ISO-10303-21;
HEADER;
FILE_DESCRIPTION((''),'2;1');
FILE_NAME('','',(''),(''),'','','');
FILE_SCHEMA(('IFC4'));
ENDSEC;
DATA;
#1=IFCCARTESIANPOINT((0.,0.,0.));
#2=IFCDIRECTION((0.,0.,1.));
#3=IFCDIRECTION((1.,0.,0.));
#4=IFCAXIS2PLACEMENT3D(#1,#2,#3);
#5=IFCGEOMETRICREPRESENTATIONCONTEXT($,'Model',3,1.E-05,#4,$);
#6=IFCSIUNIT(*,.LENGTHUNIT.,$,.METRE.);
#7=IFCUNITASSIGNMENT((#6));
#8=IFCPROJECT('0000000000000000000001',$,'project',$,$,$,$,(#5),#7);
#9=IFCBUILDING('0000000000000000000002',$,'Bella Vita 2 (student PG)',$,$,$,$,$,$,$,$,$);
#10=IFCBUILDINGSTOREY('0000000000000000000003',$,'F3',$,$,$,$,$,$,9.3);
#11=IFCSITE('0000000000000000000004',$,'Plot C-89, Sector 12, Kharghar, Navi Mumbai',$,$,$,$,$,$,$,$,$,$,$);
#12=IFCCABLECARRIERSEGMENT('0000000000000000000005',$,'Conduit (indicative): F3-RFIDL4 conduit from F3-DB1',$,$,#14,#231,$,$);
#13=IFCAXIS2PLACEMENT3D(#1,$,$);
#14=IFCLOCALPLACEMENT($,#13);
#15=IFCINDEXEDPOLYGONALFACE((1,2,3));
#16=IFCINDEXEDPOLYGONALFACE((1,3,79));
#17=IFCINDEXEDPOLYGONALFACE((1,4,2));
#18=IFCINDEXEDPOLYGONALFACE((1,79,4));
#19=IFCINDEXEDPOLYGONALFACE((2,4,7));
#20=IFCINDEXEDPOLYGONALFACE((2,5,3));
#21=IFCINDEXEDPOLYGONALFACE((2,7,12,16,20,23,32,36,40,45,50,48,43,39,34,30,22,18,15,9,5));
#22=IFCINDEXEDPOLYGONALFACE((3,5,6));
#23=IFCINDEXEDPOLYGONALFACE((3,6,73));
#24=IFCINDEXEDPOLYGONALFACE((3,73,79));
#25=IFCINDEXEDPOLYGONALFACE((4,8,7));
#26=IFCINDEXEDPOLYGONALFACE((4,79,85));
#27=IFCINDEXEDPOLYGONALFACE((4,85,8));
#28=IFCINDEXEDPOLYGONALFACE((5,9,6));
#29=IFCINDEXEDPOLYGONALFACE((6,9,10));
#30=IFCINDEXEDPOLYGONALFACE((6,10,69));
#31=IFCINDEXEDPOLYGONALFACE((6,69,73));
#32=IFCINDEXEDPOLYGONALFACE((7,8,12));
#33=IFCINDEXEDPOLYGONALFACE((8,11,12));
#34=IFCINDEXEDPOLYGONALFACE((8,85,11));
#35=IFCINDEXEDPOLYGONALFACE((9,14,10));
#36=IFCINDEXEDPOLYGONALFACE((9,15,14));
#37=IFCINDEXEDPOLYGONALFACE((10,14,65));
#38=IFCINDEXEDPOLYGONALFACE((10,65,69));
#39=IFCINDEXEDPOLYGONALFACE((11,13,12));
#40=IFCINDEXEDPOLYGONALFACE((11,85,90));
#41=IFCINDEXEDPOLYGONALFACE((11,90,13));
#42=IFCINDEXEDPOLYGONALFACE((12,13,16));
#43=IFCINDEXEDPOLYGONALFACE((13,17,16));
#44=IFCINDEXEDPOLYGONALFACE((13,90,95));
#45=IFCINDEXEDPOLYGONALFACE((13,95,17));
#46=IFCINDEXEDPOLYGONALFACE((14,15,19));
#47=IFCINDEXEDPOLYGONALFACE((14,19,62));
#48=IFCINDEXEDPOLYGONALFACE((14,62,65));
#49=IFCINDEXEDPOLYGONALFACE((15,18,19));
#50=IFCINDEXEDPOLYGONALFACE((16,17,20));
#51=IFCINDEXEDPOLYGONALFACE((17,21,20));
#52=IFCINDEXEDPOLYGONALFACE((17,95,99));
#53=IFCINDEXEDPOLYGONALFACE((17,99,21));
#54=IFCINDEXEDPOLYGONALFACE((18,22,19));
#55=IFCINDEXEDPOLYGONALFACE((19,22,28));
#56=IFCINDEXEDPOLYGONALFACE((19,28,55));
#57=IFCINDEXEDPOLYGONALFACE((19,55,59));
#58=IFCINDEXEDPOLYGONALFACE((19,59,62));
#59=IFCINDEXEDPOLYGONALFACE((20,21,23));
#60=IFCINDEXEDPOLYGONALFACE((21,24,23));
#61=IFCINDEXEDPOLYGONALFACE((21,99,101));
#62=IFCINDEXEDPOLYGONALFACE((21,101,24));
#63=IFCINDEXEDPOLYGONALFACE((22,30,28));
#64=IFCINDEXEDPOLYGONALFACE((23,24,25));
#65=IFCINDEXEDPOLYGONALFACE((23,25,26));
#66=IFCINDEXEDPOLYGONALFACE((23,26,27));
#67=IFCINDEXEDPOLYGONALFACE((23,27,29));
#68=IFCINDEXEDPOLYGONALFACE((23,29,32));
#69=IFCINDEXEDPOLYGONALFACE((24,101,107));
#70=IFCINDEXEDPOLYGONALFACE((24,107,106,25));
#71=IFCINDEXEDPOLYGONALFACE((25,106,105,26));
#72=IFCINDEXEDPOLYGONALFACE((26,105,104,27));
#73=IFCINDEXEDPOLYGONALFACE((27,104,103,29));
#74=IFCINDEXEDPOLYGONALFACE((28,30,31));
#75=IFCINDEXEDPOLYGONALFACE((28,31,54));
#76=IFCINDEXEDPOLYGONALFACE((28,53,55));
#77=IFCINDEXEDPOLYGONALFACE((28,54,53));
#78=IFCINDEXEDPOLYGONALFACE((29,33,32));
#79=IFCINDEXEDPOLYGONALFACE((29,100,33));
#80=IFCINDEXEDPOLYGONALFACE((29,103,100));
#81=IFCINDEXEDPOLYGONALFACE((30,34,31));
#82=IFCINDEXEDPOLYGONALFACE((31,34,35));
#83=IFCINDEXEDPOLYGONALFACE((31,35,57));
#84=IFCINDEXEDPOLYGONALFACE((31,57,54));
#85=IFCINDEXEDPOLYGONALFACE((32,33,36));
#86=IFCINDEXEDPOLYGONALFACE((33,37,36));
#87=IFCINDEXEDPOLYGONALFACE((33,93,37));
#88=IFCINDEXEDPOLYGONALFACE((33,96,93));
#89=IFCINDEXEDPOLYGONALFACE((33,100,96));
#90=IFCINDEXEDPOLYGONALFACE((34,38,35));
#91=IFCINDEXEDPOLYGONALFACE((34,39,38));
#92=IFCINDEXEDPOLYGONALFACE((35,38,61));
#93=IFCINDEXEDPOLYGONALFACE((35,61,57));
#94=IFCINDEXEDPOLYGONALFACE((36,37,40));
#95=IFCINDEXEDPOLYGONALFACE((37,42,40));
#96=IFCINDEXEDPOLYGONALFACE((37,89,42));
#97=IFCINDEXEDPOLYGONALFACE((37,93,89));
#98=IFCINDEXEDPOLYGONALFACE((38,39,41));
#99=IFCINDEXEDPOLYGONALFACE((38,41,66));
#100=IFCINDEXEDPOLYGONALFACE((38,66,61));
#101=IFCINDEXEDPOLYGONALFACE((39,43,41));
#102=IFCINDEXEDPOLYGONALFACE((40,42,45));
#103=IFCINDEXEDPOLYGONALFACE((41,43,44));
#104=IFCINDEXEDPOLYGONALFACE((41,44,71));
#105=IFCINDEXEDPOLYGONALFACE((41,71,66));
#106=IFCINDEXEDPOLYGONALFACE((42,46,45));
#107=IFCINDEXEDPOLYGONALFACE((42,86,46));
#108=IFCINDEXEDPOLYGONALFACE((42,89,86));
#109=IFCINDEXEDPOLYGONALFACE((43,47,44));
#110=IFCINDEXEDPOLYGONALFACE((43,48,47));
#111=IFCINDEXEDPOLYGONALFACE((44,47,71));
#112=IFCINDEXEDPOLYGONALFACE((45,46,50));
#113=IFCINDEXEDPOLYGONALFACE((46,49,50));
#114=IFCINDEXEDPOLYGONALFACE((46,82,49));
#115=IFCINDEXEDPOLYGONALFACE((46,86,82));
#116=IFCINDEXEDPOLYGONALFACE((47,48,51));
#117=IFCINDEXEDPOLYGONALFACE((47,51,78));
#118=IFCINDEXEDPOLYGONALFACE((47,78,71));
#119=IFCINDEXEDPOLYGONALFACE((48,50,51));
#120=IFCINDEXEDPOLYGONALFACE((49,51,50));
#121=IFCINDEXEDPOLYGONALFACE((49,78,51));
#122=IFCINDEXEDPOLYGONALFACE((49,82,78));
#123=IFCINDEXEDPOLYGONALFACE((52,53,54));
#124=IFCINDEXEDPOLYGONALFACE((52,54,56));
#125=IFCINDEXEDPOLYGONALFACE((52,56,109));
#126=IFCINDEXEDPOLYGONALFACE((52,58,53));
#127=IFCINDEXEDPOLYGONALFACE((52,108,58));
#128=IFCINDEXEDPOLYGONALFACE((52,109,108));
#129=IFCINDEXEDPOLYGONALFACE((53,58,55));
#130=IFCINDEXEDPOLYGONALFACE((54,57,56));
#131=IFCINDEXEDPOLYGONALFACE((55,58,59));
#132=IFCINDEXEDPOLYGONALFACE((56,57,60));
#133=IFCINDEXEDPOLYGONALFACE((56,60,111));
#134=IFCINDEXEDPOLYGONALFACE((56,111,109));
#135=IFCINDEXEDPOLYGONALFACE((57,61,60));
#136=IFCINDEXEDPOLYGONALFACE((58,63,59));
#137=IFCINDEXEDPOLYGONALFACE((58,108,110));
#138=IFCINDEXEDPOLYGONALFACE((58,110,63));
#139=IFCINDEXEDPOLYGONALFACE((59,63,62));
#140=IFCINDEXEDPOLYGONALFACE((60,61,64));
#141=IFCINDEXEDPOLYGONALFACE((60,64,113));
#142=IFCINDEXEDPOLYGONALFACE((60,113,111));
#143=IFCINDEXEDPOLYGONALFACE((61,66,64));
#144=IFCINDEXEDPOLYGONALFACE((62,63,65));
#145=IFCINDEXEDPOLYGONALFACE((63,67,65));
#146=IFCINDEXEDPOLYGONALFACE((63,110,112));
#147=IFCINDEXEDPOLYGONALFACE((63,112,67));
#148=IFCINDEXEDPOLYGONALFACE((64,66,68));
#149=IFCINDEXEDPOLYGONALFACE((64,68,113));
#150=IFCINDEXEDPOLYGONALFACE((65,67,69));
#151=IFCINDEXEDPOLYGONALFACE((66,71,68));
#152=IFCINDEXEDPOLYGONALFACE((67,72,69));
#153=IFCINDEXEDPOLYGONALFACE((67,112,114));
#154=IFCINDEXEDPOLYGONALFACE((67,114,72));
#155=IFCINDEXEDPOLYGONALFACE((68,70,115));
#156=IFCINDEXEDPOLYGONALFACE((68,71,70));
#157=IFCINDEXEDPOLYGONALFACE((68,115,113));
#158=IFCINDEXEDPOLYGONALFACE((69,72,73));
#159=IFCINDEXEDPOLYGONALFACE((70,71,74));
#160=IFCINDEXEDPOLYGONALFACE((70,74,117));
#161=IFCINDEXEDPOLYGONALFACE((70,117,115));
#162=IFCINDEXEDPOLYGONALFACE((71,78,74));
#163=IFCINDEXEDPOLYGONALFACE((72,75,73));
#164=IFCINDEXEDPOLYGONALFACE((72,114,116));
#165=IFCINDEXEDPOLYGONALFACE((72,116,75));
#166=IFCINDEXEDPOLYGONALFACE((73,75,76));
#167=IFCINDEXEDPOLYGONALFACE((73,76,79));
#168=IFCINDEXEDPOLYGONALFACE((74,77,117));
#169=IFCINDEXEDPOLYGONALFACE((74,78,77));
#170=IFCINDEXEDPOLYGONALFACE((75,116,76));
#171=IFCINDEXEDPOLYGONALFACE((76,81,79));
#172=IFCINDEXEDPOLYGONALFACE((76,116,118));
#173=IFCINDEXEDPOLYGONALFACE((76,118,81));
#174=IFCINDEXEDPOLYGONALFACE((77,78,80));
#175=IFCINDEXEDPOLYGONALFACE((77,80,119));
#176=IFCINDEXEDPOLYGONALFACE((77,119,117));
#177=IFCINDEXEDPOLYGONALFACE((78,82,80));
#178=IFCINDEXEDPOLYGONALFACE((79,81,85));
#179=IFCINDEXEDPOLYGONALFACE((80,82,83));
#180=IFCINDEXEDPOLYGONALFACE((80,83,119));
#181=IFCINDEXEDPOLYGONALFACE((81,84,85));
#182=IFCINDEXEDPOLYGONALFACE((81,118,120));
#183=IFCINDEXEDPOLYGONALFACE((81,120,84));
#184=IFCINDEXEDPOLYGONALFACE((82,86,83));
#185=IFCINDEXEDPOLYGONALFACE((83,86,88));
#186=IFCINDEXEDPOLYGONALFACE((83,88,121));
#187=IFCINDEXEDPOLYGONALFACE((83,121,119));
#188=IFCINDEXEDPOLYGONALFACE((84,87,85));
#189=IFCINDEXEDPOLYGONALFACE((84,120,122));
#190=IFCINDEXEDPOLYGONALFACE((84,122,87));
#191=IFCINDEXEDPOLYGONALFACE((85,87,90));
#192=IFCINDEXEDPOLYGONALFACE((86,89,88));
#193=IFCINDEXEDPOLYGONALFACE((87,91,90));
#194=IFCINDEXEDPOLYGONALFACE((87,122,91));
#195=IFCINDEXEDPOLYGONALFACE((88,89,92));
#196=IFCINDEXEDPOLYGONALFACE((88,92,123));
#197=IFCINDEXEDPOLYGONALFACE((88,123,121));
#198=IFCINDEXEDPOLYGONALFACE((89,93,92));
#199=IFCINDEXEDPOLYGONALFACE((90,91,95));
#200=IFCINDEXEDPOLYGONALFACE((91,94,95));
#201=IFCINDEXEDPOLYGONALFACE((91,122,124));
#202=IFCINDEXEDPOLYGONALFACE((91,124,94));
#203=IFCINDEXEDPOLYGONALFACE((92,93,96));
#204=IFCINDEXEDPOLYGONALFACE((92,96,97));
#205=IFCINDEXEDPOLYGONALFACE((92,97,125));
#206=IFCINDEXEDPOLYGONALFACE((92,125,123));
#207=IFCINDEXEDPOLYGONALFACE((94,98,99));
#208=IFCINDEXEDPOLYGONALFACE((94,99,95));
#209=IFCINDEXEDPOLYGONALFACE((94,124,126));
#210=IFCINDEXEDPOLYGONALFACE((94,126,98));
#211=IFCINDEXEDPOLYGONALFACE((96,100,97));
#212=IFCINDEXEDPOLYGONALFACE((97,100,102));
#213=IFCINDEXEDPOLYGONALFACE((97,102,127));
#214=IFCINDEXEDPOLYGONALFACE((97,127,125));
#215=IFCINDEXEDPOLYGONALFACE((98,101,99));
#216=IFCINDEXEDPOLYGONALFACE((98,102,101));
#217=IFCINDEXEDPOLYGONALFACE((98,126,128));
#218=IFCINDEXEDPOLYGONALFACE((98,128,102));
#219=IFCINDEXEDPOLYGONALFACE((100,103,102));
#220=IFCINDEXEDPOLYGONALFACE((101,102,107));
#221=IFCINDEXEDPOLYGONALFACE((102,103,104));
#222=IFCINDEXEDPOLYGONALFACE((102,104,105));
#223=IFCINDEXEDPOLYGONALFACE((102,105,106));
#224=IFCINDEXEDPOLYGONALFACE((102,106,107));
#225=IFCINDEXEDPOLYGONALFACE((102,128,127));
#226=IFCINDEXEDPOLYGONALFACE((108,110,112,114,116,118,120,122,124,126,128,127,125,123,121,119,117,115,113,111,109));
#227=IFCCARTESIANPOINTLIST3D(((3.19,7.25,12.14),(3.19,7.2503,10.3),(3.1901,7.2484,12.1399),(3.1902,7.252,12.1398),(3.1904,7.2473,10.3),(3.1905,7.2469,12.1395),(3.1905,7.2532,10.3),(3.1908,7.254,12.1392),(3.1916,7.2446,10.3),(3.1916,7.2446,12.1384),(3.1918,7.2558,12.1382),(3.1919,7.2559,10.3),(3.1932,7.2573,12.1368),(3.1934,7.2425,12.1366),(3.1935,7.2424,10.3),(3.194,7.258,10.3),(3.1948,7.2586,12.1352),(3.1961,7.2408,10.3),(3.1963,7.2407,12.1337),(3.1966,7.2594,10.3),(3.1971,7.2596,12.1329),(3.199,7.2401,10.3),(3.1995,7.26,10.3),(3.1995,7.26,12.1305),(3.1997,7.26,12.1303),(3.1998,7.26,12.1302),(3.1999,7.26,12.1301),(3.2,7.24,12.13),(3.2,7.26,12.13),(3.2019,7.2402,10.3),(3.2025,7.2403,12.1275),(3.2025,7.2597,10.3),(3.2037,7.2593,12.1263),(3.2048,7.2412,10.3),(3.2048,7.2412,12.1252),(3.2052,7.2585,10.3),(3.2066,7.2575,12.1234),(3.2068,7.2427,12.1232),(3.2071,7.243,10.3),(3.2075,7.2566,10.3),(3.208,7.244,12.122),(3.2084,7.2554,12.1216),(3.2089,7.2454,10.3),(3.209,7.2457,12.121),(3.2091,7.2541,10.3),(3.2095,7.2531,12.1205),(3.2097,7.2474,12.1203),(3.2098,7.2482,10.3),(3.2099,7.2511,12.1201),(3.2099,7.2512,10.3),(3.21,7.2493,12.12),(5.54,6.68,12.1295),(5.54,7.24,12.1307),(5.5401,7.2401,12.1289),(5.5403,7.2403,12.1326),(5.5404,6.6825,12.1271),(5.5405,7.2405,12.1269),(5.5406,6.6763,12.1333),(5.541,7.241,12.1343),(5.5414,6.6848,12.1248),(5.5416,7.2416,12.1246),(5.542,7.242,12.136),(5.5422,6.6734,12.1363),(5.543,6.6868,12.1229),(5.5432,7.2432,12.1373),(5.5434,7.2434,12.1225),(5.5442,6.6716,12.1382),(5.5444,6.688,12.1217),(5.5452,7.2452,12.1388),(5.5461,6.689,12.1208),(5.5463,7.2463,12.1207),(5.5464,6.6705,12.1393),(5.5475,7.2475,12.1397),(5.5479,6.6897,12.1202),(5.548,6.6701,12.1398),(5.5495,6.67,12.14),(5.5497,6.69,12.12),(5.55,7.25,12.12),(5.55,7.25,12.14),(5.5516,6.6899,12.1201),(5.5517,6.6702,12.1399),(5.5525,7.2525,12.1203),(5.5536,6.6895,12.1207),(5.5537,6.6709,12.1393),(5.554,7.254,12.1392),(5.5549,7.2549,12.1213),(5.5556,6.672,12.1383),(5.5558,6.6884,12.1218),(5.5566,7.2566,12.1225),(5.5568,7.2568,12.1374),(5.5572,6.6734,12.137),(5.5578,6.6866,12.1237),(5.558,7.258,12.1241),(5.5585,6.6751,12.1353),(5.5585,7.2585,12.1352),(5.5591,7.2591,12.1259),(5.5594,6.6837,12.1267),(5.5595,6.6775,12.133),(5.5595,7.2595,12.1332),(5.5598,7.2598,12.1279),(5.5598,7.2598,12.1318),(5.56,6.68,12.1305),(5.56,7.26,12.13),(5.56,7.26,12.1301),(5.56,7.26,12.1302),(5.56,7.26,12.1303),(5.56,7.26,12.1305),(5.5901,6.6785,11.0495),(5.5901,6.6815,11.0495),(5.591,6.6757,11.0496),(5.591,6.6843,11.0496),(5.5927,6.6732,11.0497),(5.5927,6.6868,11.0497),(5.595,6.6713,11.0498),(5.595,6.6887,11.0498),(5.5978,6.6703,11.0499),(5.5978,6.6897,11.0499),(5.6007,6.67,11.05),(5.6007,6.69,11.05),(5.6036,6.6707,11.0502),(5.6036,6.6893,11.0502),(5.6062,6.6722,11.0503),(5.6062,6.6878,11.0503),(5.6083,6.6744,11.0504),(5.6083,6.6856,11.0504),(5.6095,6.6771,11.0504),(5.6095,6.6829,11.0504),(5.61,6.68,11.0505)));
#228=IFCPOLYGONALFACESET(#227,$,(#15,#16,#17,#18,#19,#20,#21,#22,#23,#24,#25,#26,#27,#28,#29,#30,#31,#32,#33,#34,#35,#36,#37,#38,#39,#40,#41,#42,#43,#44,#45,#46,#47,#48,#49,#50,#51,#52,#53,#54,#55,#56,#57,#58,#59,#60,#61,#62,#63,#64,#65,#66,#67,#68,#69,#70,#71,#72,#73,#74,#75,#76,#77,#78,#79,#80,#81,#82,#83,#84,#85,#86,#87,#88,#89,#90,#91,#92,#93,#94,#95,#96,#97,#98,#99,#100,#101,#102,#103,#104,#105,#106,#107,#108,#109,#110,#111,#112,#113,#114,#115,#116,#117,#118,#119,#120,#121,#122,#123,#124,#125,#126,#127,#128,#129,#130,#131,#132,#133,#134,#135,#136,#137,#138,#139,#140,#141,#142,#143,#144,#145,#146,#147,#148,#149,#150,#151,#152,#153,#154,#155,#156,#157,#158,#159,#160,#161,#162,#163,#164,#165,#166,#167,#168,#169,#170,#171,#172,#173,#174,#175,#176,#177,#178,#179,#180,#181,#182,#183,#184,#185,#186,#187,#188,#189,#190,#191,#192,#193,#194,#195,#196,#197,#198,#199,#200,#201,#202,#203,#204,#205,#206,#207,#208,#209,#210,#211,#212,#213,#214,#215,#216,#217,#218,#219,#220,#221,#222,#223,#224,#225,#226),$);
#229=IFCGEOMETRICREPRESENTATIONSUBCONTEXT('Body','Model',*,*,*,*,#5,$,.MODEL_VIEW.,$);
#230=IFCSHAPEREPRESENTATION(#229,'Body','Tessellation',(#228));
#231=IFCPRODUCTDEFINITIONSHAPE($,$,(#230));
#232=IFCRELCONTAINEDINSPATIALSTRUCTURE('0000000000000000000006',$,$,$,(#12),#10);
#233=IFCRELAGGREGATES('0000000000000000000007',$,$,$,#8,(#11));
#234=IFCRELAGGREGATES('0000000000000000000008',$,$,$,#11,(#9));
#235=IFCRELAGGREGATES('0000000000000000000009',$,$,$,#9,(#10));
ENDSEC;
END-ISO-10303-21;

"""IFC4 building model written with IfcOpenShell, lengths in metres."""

from ifc_helpers import new_model, entity, si_unit, origin, origin_with_axes, place, context, subcontext, project, spatial, element, save


model = new_model("IFC4")

# Units and contexts
model_context = context("Model", 3, precision=1e-05, world=origin_with_axes())
body_context = subcontext(model_context, "Body", "Model", "MODEL_VIEW")
ifc_project = project(units=[si_unit("LENGTHUNIT", "METRE")], contexts=[model_context])

# Site, building, storey
site = spatial("IfcSite", under=ifc_project, Name="Plot C-89, Sector 12, Kharghar, Navi Mumbai")
building = spatial("IfcBuilding", under=site, Name="Bella Vita 2 (student PG)")
storey = spatial("IfcBuildingStorey", under=building, Name="F3", Elevation=9.3)

# Cable carrier segment
cable_carrier_segment_1_placement = place(None, origin())
element("IfcCableCarrierSegment", 1, at=cable_carrier_segment_1_placement, inside=storey, Name="Conduit (indicative): F3-RFIDL4 conduit from F3-DB1", context=body_context, shape_type="AdvancedSweptSolid", body=[
    entity("IfcSweptDiskSolid", entity("IfcPolyline", [entity("IfcCartesianPoint", [5.6, 6.68, 11.05]), entity("IfcCartesianPoint", [5.55, 6.68, 12.13]), entity("IfcCartesianPoint", [5.55, 7.25, 12.13]), entity("IfcCartesianPoint", [3.2, 7.25, 12.13]), entity("IfcCartesianPoint", [3.2, 7.25, 10.3])]), 0.01),
])

save(model, "model.ifc")
